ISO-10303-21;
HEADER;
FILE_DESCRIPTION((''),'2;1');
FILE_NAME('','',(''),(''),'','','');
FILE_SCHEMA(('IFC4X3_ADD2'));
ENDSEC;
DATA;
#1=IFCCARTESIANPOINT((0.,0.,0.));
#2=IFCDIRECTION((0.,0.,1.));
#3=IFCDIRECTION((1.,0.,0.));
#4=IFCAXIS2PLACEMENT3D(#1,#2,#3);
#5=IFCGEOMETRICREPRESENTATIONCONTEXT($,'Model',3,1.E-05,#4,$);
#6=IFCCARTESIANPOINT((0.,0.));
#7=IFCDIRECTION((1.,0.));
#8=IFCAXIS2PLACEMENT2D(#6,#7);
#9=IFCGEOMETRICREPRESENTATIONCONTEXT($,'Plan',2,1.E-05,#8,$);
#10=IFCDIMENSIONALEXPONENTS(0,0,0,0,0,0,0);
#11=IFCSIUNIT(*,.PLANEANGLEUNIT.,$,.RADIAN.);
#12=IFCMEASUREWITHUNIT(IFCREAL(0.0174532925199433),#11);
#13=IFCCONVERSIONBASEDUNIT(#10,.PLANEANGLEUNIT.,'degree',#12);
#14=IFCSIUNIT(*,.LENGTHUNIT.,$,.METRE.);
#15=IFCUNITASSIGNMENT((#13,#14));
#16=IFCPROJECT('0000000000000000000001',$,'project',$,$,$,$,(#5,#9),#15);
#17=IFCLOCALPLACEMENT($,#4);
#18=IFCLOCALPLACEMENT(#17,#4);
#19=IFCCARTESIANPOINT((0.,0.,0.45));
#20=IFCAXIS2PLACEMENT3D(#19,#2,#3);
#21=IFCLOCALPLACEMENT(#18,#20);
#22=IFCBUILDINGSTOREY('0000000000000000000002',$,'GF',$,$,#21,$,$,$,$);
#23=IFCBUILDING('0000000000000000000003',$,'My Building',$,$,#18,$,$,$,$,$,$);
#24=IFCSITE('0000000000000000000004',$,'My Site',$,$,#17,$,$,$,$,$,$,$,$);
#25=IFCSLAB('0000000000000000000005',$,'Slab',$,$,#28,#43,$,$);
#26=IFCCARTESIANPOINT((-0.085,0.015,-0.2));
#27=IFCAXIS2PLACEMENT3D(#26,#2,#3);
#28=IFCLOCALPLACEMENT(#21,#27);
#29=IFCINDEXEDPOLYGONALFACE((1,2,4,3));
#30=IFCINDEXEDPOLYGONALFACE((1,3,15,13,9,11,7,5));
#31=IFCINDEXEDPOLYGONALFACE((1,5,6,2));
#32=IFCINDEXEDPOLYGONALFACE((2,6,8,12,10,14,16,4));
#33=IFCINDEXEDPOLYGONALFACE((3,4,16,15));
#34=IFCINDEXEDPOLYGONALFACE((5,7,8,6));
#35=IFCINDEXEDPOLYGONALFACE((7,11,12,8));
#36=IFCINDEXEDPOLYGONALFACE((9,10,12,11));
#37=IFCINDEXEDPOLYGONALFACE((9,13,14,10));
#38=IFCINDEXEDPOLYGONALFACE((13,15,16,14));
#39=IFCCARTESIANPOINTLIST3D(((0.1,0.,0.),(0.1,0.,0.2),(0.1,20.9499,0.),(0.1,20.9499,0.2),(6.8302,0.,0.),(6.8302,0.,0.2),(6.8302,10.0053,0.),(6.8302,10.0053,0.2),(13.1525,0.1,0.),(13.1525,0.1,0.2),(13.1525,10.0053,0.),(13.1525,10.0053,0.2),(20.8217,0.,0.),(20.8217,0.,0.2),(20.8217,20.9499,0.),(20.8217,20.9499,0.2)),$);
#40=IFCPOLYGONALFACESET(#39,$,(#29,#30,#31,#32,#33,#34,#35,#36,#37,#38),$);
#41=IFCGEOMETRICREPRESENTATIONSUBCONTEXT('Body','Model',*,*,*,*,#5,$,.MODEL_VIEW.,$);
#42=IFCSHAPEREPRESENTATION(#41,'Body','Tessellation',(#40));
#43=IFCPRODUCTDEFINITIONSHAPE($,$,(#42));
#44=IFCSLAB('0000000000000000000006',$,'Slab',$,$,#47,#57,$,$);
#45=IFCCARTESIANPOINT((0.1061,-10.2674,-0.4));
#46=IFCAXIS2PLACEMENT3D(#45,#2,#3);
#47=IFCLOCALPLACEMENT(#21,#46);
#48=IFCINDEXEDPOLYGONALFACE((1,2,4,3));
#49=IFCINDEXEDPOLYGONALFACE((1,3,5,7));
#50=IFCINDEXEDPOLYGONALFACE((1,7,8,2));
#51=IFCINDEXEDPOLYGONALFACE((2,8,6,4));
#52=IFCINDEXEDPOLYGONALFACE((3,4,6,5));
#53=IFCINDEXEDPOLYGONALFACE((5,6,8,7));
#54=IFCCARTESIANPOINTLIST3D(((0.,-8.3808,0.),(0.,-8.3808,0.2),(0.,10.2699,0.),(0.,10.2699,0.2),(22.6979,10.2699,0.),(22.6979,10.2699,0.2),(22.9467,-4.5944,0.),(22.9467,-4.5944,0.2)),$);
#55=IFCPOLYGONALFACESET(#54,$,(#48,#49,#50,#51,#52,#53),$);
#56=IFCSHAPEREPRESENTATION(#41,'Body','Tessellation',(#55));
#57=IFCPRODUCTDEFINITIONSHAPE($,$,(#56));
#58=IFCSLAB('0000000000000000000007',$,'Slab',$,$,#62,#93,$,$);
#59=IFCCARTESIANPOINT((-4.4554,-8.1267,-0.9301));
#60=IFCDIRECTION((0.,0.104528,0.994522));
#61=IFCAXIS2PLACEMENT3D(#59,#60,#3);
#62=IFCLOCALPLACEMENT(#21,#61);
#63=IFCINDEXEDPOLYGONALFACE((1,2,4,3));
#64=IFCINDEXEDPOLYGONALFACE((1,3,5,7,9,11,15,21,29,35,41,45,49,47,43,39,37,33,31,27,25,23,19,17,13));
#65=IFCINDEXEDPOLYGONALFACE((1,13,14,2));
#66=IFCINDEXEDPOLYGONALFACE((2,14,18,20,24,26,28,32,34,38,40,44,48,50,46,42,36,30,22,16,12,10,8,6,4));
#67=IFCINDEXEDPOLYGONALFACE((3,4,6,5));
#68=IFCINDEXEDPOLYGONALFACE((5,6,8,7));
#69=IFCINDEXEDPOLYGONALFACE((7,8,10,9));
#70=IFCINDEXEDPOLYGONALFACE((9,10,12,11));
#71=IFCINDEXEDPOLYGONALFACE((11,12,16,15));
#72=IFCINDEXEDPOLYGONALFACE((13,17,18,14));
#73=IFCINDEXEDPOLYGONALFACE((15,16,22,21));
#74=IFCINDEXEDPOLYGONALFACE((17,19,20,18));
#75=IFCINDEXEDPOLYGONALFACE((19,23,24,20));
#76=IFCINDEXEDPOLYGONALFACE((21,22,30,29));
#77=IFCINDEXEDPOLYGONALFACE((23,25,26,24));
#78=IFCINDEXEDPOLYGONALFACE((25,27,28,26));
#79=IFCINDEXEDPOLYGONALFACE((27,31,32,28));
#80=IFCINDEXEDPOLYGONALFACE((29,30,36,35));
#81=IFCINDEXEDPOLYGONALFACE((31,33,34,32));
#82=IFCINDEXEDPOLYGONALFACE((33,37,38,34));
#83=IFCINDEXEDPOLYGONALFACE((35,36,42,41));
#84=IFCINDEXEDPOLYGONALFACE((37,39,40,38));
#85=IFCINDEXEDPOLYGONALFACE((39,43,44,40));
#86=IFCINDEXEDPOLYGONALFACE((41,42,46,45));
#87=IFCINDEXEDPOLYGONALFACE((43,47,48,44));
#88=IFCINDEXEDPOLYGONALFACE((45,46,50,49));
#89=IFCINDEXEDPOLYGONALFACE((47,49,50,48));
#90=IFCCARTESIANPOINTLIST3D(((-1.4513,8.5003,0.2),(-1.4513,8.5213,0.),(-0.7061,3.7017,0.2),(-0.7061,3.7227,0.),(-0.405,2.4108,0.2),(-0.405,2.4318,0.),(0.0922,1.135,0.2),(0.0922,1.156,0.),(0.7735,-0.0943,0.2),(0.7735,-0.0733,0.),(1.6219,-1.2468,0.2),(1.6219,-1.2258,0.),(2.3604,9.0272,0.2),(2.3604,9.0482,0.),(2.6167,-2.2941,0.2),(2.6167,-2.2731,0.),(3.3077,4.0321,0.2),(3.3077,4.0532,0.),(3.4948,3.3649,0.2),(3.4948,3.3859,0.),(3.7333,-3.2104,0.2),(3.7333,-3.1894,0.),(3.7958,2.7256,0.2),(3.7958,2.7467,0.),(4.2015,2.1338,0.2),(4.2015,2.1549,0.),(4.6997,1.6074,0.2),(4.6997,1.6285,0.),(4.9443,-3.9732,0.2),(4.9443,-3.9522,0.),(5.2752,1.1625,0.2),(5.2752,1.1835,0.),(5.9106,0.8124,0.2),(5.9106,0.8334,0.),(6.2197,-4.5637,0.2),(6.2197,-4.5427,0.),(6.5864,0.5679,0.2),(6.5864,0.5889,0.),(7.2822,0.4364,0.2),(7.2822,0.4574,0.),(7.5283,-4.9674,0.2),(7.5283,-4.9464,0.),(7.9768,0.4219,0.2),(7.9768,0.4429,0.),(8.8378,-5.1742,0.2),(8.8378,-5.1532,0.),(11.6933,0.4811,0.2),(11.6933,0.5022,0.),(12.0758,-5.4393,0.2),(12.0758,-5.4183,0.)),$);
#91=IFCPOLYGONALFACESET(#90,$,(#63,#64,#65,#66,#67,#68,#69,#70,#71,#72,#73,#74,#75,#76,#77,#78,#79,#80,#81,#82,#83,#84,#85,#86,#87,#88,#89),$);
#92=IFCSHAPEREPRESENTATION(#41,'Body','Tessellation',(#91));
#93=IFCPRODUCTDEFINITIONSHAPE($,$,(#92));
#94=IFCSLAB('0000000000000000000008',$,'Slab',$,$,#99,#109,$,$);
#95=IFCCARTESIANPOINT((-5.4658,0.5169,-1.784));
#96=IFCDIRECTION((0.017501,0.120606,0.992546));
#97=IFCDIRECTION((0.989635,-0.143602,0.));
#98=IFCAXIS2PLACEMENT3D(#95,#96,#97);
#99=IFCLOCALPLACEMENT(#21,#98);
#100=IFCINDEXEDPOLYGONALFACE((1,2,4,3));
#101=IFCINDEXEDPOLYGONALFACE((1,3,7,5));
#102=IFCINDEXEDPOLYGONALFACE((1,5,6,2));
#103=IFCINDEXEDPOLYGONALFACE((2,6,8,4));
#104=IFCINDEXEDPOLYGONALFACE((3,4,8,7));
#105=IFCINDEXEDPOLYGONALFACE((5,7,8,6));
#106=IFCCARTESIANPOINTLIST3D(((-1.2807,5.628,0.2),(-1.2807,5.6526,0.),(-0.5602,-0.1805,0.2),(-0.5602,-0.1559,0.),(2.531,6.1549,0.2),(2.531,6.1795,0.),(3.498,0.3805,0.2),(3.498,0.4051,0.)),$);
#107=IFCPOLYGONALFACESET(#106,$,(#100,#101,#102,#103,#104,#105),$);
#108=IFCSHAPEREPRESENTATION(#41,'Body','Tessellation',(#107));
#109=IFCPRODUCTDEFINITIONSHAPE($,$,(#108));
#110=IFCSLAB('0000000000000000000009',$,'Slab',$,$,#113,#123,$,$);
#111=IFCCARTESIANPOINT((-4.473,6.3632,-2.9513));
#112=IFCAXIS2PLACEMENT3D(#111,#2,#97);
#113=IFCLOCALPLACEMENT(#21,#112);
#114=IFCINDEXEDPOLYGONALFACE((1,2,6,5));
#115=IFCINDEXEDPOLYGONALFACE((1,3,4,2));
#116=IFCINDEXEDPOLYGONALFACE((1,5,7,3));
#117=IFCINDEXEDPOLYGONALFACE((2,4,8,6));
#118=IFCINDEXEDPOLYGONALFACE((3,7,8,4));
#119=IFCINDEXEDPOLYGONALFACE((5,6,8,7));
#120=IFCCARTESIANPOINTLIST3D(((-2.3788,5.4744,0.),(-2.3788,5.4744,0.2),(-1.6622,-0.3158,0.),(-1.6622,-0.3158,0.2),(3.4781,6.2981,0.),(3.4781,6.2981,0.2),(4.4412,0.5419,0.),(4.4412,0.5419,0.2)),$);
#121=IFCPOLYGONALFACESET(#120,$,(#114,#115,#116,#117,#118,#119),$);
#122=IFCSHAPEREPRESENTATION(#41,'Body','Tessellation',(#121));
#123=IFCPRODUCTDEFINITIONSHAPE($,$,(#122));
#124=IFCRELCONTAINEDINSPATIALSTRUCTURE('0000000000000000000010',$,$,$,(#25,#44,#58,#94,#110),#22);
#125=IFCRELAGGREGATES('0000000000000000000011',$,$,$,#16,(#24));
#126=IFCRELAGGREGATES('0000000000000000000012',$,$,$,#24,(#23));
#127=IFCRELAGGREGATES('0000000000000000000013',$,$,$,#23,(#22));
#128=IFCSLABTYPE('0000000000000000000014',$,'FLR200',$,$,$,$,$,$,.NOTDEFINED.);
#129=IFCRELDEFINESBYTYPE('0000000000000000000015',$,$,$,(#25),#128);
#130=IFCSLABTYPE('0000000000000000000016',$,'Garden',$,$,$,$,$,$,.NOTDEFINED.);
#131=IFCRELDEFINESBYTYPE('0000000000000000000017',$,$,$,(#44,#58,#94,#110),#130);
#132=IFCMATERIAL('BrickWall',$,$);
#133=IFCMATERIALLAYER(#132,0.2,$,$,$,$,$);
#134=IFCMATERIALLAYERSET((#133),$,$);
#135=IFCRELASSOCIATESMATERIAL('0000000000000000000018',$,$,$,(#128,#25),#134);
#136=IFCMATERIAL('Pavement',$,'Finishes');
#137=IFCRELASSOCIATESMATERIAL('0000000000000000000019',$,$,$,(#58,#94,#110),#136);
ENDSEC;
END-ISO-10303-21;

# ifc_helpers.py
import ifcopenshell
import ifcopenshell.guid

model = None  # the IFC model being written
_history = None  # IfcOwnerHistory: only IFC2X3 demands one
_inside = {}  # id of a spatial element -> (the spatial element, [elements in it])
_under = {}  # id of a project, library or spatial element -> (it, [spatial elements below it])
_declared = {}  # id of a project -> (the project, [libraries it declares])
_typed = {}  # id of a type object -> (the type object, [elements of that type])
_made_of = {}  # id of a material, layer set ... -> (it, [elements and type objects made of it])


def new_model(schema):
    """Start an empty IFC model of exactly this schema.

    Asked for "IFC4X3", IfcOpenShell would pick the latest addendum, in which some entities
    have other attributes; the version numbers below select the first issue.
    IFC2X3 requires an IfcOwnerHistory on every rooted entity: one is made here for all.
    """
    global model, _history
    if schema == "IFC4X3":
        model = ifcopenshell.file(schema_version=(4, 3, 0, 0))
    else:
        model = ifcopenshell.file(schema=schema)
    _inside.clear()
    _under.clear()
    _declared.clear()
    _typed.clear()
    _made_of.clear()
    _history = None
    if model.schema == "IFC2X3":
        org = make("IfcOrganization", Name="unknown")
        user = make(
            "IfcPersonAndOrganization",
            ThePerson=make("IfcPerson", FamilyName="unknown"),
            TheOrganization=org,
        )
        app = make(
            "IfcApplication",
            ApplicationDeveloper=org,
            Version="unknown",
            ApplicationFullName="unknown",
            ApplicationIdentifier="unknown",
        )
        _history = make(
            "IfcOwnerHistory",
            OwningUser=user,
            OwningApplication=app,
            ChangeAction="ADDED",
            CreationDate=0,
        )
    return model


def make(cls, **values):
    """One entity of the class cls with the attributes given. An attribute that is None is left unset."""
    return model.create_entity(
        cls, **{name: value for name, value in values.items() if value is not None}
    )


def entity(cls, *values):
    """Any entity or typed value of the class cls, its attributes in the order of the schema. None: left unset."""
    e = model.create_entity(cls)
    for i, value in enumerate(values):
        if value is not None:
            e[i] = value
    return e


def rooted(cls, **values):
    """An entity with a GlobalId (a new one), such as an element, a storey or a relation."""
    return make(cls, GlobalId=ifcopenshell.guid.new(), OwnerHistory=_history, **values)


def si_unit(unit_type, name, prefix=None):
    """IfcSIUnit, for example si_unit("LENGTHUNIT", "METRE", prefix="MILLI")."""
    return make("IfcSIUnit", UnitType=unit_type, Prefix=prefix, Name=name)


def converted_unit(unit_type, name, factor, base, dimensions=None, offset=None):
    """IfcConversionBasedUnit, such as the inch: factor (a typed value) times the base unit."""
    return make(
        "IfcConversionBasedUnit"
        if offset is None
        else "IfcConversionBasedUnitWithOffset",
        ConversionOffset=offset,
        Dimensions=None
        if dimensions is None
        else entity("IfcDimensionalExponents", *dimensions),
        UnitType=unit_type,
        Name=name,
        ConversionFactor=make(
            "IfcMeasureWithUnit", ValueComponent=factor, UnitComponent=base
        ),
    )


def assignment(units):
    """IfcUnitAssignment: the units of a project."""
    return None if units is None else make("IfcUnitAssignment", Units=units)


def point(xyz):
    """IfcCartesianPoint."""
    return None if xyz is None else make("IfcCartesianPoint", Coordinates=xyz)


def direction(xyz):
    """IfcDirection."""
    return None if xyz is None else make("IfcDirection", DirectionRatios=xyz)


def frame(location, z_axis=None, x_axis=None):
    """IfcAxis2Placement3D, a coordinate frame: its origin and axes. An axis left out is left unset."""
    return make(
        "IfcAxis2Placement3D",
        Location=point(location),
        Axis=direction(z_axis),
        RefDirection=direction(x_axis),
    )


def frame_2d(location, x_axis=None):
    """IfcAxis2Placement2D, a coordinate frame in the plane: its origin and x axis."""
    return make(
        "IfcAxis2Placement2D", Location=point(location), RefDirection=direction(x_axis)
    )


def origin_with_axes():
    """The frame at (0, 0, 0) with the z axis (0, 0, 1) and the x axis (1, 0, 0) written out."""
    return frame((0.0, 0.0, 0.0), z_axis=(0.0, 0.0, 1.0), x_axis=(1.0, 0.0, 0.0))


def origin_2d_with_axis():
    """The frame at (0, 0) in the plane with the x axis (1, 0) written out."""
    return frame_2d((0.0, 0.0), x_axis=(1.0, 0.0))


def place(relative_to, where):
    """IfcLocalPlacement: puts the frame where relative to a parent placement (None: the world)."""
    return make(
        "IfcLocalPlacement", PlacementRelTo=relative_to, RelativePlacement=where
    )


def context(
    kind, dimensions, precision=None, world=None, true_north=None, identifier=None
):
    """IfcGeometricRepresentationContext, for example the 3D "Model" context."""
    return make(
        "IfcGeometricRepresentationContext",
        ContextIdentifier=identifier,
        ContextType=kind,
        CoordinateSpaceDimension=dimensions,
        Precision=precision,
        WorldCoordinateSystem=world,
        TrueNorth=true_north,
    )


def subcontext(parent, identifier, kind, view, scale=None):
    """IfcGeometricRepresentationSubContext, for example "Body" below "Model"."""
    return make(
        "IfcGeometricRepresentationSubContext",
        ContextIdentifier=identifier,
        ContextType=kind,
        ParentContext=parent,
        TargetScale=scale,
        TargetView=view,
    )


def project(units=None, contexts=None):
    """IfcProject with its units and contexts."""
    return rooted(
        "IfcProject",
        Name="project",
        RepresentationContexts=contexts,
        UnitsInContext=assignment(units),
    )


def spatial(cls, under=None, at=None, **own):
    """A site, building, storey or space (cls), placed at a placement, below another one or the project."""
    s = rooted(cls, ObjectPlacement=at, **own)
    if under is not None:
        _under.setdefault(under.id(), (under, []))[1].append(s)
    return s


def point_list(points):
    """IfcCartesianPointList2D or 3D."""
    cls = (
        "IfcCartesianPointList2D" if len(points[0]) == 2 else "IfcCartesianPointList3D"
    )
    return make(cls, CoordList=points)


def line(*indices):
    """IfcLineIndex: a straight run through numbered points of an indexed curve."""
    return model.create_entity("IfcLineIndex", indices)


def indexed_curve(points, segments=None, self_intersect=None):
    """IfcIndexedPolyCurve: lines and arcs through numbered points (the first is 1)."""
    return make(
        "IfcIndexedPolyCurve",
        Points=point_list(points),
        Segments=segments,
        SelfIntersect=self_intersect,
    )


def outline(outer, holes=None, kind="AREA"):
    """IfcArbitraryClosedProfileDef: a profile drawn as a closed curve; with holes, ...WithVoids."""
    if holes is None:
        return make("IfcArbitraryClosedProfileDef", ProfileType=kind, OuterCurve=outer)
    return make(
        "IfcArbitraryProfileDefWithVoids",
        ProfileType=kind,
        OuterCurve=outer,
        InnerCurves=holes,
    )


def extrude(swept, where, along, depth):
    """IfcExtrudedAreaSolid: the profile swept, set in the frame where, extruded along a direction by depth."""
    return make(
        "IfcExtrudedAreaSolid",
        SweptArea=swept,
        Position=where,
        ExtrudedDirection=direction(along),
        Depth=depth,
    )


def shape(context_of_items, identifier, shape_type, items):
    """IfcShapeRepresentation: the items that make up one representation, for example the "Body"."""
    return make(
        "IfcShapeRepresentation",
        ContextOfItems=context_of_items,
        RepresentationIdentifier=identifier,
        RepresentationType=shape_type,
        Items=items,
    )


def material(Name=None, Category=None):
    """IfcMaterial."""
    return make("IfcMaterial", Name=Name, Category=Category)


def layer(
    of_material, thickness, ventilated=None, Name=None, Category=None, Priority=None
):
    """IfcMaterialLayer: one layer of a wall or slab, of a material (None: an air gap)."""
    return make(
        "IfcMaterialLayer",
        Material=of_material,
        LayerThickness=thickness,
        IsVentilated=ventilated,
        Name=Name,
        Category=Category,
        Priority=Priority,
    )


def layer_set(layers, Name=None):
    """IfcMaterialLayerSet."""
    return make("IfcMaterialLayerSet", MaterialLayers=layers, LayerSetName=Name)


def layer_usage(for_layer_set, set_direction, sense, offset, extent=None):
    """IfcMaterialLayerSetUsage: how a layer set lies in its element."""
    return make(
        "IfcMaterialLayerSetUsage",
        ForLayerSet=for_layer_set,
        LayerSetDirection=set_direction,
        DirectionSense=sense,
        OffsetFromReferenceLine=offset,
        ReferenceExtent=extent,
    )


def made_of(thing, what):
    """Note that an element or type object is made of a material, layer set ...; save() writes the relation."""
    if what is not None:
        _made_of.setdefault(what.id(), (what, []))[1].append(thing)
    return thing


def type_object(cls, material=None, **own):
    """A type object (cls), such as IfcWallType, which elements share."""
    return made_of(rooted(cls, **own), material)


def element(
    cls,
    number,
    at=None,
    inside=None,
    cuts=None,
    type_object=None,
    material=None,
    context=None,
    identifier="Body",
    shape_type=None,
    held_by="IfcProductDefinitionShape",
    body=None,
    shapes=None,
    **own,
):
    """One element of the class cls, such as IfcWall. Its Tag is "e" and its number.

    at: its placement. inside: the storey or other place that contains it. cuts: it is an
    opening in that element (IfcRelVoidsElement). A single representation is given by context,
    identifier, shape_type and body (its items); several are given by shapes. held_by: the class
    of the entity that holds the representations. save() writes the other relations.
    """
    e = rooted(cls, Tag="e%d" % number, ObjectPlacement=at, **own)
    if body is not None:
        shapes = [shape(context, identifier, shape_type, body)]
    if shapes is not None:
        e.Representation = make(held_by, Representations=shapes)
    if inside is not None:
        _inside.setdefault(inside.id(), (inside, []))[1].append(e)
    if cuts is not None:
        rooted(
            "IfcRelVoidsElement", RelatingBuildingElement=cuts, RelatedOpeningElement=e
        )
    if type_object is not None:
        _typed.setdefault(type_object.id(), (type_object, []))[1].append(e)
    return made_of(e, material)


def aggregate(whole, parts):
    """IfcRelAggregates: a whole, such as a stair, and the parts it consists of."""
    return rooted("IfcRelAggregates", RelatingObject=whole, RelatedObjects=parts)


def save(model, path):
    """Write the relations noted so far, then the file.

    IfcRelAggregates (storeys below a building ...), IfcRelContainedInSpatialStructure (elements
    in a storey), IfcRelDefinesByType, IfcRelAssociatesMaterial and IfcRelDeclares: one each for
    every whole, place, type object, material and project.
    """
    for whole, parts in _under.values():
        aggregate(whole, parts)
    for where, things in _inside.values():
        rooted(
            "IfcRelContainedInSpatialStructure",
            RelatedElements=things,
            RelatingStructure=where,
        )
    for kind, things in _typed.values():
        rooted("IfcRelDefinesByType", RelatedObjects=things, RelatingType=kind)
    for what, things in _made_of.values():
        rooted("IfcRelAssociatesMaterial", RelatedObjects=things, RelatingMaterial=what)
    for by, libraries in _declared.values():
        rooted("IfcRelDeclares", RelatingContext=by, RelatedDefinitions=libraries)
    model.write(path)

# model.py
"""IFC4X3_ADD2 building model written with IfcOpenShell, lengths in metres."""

from ifc_helpers import new_model, entity, si_unit, converted_unit, frame, origin_with_axes, origin_2d_with_axis, place, context, subcontext, project, spatial, line, indexed_curve, outline, extrude, material, layer, layer_set, layer_usage, type_object, element, save


model = new_model("IFC4X3_ADD2")

# Units and contexts
model_context = context("Model", 3, precision=1e-05, world=origin_with_axes())
plan_context = context("Plan", 2, precision=1e-05, world=origin_2d_with_axis())
body_context_1 = subcontext(model_context, "Body", "Model", "MODEL_VIEW")
ifc_project = project(units=[converted_unit("PLANEANGLEUNIT", "degree", entity("IfcReal", 0.0174532925199433), si_unit("PLANEANGLEUNIT", "RADIAN"), dimensions=[0, 0, 0, 0, 0, 0, 0]), si_unit("LENGTHUNIT", "METRE")], contexts=[model_context, plan_context])

# Site, building, storey
site_placement = place(None, origin_with_axes())
site = spatial("IfcSite", under=ifc_project, at=site_placement, Name="My Site")
building_placement = place(site_placement, origin_with_axes())
building = spatial("IfcBuilding", under=site, at=building_placement, Name="My Building")
storey_placement = place(building_placement, frame((0.0, 0.0, 0.45), z_axis=(0.0, 0.0, 1.0), x_axis=(1.0, 0.0, 0.0)))
storey = spatial("IfcBuildingStorey", under=building, at=storey_placement, Name="GF")

# Slabs
ifc_material_1 = material(Name="BrickWall")
ifc_layer_1 = layer(ifc_material_1, 0.2)
ifc_layer_set_1 = layer_set([ifc_layer_1])
ifc_layer_usage_1 = layer_usage(ifc_layer_set_1, "AXIS3", "POSITIVE", 0.0)
slab_type_1 = type_object("IfcSlabType", Name="FLR200", PredefinedType="NOTDEFINED", material=ifc_layer_set_1)
slab_1_placement = place(storey_placement, frame((-0.085, 0.015, -0.2), z_axis=(0.0, 0.0, 1.0), x_axis=(1.0, 0.0, 0.0)))
element("IfcSlab", 1, at=slab_1_placement, inside=storey, type_object=slab_type_1, material=ifc_layer_usage_1, Name="Slab", context=body_context_1, shape_type="SweptSolid", body=[
    extrude(outline(indexed_curve([(0.1, 20.9499), (0.1, 0.0), (6.8302, 0.0), (6.8302, 10.0053), (13.1525, 10.0053), (13.1525, 0.1), (20.8217, 0.0), (20.8217, 20.9499)], segments=[line(5, 6), line(6, 7), line(7, 8), line(8, 1), line(1, 2), line(2, 3), line(3, 4), line(4, 5)], self_intersect=False)), None, (0.0, 0.0, 1.0), 0.2),
])
slab_type_2 = type_object("IfcSlabType", Name="Garden", PredefinedType="NOTDEFINED")
slab_2_placement = place(storey_placement, frame((0.1061, -10.2674, -0.4), z_axis=(0.0, 0.0, 1.0), x_axis=(1.0, 0.0, 0.0)))
element("IfcSlab", 2, at=slab_2_placement, inside=storey, type_object=slab_type_2, Name="Slab", context=body_context_1, shape_type="SweptSolid", body=[
    extrude(outline(indexed_curve([(0.0, 10.2699), (0.0, -8.3808), (22.9467, -4.5944), (22.6979, 10.2699)], segments=[line(4, 1), line(1, 2), line(2, 3), line(3, 4)], self_intersect=False)), None, (0.0, 0.0, 1.0), 0.2),
])
ifc_material_2 = material(Name="Pavement", Category="Finishes")
slab_3_placement = place(storey_placement, frame((-4.4554, -8.1267, -0.9301), z_axis=(0.0, 0.104528, 0.994522), x_axis=(1.0, 0.0, 0.0)))
element("IfcSlab", 3, at=slab_3_placement, inside=storey, type_object=slab_type_2, material=ifc_material_2, Name="Slab", context=body_context_1, shape_type="SweptSolid", body=[
    extrude(outline(indexed_curve([(-1.4513, 8.5213), (2.3604, 9.0482), (11.6933, 0.5022), (12.0758, -5.4183), (3.3077, 4.0532), (7.9768, 0.4429), (3.4948, 3.3859), (3.7958, 2.7467), (4.2015, 2.1549), (4.6997, 1.6285), (5.2752, 1.1835), (5.9106, 0.8334), (6.5864, 0.5889), (7.2822, 0.4574), (8.8378, -5.1532), (-0.7061, 3.7227), (7.5283, -4.9464), (6.2197, -4.5427), (4.9443, -3.9522), (3.7333, -3.1894), (2.6167, -2.2731), (1.6219, -1.2258), (0.7735, -0.0733), (0.0922, 1.156), (-0.405, 2.4318)], segments=[line(16, 25), line(25, 24), line(24, 23), line(23, 22), line(22, 21), line(21, 20), line(20, 19), line(19, 18), line(18, 17), line(17, 15), line(15, 4), line(4, 3), line(3, 6), line(6, 14), line(14, 13), line(13, 12), line(12, 11), line(11, 10), line(10, 9), line(9, 8), line(8, 7), line(7, 5), line(5, 2), line(2, 1), line(1, 16)], self_intersect=False)), None, (0.0, -0.104528, 0.994522), 0.2011),
])
slab_4_placement = place(storey_placement, frame((-5.4658, 0.5169, -1.784), z_axis=(0.017501, 0.120606, 0.992546), x_axis=(0.989635, -0.143602, 0.0)))
element("IfcSlab", 4, at=slab_4_placement, inside=storey, type_object=slab_type_2, material=ifc_material_2, Name="Slab", context=body_context_1, shape_type="SweptSolid", body=[
    extrude(outline(indexed_curve([(-1.2807, 5.6526), (2.531, 6.1795), (3.498, 0.4051), (-0.5602, -0.1559)], segments=[line(4, 1), line(1, 2), line(2, 3), line(3, 4)], self_intersect=False)), None, (0.0, -0.121869, 0.992546), 0.2015),
])
slab_5_placement = place(storey_placement, frame((-4.473, 6.3632, -2.9513), z_axis=(0.0, 0.0, 1.0), x_axis=(0.989635, -0.143602, 0.0)))
element("IfcSlab", 5, at=slab_5_placement, inside=storey, type_object=slab_type_2, material=ifc_material_2, Name="Slab", context=body_context_1, shape_type="SweptSolid", body=[
    extrude(outline(indexed_curve([(4.4412, 0.5419), (3.4781, 6.2981), (-2.3788, 5.4744), (-1.6622, -0.3158)], segments=[line(3, 2), line(2, 1), line(1, 4), line(4, 3)], self_intersect=False)), None, (0.0, 0.0, 1.0), 0.2),
])

save(model, "model.ifc")
